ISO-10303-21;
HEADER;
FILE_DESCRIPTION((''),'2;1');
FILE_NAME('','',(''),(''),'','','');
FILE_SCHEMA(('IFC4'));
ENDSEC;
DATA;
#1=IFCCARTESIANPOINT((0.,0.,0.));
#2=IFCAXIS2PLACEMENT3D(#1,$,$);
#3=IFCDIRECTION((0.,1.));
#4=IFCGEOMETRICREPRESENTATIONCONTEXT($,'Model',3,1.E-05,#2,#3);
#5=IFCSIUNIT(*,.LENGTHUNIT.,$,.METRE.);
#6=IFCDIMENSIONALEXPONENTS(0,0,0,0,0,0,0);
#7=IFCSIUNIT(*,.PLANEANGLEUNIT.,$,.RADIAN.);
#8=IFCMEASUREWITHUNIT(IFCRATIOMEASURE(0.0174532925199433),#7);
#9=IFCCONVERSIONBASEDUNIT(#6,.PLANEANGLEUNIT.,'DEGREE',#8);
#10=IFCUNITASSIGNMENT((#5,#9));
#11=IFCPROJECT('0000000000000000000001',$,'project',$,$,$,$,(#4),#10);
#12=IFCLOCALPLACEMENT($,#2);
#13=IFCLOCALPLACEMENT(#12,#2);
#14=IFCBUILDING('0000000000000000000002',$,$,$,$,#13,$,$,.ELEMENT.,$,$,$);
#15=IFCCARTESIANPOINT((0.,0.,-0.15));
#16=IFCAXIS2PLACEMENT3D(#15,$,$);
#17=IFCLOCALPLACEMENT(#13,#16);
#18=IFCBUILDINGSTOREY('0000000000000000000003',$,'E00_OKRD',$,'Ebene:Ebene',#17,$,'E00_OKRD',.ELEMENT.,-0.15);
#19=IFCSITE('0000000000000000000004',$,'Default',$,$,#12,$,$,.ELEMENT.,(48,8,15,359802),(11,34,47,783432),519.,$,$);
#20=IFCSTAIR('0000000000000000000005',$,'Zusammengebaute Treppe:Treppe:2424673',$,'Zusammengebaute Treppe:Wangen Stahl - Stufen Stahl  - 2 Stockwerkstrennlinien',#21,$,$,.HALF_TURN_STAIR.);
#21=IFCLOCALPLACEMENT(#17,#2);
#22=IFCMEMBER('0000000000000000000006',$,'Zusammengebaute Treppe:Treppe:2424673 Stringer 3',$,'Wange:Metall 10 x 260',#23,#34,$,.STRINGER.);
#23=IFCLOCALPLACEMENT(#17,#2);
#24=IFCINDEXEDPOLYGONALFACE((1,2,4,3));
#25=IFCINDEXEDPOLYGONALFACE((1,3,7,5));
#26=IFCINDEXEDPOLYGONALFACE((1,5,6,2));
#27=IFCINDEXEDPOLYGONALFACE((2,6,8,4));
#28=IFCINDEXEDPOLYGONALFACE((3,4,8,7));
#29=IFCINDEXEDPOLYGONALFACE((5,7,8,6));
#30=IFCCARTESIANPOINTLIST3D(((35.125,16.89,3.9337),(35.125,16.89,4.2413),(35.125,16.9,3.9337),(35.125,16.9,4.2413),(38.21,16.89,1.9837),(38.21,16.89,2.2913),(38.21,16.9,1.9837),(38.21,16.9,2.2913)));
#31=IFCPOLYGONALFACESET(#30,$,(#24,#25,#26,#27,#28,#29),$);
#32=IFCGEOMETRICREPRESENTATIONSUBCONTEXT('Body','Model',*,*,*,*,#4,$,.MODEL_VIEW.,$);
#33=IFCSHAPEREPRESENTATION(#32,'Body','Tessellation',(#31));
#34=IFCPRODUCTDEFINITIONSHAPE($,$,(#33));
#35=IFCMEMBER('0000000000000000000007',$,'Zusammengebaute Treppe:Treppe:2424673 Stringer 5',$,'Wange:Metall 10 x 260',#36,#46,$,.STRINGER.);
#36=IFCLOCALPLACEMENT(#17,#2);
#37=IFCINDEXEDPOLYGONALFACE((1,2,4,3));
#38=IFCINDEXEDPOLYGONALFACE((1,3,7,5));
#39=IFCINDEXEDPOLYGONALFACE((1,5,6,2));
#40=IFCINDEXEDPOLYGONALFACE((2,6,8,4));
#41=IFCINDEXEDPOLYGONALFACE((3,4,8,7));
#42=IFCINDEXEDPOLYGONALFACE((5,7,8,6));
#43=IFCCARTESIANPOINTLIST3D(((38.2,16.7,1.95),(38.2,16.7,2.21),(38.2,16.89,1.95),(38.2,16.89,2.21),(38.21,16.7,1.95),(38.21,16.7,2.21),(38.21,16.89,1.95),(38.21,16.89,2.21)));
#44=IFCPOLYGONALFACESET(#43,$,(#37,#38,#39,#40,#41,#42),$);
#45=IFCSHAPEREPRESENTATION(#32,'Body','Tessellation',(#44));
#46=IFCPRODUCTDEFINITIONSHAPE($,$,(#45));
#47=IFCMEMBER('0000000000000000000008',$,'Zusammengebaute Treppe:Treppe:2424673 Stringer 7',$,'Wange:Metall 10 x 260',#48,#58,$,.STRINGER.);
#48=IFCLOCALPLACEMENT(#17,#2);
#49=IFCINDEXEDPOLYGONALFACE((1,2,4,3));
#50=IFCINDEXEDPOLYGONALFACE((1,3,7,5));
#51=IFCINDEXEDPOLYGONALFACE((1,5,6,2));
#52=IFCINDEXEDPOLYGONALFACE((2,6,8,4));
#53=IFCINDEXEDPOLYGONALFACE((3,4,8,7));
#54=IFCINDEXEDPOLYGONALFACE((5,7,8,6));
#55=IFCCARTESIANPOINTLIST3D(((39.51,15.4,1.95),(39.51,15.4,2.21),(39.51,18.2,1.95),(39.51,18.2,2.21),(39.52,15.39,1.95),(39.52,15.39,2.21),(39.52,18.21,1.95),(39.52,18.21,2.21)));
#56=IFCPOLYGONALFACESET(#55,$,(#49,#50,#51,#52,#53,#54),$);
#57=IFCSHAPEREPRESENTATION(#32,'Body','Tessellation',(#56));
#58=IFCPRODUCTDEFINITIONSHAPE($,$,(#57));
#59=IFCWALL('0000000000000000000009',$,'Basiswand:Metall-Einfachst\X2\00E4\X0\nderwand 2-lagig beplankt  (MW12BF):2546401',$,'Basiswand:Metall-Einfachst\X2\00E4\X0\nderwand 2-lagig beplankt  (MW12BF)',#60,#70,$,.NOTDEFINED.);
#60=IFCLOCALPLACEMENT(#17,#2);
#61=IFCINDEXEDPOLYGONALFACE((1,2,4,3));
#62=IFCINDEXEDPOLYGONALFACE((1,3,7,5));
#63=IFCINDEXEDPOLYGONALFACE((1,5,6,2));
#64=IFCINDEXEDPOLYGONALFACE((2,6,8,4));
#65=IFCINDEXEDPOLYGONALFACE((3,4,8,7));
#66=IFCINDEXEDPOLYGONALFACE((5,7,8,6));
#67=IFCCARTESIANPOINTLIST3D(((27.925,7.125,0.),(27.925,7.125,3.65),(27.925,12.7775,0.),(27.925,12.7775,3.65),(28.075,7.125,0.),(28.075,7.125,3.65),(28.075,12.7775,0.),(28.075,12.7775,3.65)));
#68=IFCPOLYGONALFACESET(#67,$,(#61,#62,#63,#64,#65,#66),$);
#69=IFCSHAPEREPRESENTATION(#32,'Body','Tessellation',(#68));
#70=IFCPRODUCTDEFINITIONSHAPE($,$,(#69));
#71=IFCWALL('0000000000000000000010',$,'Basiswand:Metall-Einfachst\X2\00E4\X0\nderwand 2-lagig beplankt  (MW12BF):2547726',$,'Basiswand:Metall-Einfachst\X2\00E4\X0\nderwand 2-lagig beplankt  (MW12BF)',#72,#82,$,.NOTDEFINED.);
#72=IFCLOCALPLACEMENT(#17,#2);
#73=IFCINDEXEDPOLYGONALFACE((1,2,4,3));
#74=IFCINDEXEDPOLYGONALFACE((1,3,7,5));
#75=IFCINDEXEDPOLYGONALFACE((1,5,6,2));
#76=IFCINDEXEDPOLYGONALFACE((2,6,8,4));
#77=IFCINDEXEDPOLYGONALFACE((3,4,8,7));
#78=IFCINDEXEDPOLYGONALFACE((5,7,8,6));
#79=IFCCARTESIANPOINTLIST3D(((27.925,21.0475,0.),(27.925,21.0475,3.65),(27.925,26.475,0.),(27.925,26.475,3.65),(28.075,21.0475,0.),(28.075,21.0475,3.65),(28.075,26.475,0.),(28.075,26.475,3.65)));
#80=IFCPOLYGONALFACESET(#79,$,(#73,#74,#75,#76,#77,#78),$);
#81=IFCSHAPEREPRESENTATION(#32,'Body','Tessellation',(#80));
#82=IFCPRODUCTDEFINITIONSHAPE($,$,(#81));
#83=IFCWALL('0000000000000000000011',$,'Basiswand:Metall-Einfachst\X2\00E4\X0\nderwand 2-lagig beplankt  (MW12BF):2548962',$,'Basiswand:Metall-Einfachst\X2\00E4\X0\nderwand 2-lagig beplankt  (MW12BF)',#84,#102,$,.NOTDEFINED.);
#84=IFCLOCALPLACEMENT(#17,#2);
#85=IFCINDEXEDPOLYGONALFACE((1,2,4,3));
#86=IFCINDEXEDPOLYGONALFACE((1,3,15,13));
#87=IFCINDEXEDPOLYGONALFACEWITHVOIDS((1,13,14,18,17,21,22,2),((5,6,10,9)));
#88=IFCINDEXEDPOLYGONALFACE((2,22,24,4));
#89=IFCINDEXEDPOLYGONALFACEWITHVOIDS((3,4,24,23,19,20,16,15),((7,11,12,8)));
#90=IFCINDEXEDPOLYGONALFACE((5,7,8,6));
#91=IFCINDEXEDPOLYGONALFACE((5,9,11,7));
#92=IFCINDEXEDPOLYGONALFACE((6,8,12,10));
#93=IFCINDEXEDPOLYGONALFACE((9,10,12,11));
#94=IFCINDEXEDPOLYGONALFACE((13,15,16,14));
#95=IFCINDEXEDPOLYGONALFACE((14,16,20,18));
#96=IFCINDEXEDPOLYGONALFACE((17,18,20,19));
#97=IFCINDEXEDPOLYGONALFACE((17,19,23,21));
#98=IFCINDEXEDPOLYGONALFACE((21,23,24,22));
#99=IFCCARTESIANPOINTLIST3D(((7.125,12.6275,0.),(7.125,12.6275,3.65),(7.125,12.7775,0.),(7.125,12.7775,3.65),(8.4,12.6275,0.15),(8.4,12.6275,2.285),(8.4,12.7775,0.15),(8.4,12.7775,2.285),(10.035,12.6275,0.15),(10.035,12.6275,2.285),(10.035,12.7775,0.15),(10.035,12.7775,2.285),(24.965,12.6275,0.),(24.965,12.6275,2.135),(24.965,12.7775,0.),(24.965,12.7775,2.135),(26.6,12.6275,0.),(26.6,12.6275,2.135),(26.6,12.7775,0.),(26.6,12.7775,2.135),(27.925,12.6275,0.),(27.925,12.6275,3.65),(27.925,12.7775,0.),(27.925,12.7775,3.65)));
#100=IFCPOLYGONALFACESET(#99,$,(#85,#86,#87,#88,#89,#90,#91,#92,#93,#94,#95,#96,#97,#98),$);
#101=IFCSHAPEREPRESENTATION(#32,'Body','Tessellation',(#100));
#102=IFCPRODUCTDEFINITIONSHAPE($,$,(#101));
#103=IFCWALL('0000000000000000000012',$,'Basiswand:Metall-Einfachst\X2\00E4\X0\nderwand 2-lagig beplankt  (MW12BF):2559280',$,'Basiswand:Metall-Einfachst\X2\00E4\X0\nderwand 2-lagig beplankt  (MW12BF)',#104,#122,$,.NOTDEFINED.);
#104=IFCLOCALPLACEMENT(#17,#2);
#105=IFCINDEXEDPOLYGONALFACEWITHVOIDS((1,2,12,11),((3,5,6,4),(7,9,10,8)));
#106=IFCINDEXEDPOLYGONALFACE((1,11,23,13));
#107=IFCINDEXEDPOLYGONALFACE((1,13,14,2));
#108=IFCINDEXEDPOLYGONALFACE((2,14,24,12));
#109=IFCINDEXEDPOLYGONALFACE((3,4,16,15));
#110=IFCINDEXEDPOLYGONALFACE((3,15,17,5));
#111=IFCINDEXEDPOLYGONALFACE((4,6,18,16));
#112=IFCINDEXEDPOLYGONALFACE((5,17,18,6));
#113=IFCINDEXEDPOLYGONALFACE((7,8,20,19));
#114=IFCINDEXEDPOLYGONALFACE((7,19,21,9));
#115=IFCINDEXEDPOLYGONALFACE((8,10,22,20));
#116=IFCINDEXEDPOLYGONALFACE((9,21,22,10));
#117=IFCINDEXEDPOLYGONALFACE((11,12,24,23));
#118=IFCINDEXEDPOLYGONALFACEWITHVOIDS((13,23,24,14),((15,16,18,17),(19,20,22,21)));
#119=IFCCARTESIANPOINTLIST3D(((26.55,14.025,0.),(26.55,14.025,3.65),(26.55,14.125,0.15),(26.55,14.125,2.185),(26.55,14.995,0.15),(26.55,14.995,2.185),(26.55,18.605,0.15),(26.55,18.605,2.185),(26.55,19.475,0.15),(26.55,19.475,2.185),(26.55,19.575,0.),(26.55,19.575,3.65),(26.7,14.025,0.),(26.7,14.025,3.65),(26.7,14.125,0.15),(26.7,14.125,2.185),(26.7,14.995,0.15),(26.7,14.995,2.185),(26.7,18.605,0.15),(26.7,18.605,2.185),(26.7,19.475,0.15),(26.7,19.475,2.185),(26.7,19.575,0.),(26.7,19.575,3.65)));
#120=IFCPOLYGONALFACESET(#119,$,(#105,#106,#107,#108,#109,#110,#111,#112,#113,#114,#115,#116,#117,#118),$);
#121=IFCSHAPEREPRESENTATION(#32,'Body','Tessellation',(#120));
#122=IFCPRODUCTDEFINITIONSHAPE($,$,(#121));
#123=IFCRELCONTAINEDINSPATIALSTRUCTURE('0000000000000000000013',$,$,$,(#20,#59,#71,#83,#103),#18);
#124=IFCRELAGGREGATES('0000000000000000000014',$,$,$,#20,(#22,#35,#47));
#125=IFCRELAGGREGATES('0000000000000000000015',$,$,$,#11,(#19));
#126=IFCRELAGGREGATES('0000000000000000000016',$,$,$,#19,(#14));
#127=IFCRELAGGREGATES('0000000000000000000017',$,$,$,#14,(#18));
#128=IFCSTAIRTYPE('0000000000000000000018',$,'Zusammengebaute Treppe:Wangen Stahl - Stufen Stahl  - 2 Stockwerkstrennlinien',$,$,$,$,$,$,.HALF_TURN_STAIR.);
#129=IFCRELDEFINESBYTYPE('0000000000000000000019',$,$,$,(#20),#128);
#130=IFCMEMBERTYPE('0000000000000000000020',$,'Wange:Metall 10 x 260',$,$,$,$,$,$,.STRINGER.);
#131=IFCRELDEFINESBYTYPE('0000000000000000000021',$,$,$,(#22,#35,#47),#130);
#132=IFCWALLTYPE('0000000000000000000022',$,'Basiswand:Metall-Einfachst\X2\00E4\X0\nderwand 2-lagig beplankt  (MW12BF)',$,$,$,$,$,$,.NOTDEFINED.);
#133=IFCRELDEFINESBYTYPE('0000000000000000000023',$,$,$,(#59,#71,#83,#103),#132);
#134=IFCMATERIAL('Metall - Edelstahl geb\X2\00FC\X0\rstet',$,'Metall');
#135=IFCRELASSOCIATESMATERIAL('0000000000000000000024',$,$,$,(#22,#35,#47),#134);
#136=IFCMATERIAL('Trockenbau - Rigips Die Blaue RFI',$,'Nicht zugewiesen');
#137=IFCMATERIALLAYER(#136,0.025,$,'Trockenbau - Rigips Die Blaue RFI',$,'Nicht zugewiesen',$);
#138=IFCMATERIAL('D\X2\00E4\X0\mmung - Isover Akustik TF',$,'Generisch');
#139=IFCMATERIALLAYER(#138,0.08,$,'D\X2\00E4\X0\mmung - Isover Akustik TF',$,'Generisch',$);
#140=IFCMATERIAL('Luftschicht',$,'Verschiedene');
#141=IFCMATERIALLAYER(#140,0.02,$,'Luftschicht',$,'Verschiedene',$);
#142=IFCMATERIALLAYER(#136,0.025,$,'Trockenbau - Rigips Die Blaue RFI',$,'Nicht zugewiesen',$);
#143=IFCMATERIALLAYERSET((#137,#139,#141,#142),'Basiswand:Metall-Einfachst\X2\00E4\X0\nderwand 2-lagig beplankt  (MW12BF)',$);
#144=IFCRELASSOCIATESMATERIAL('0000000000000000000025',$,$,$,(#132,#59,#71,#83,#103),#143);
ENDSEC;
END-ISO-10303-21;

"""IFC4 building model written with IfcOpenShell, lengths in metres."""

from ifc_helpers import new_model, entity, si_unit, converted_unit, direction, frame, frame_2d, origin, place, context, subcontext, project, spatial, polyline, rectangle, outline, extrude, material, layer, layer_set, layer_usage, type_object, element, aggregate, save


model = new_model("IFC4")

# Units and contexts
model_context = context("Model", 3, precision=1e-05, world=origin(), true_north=direction((0.0, 1.0)))
body_context = subcontext(model_context, "Body", "Model", "MODEL_VIEW")
ifc_project = project(units=[si_unit("LENGTHUNIT", "METRE"), converted_unit("PLANEANGLEUNIT", "DEGREE", entity("IfcRatioMeasure", 0.0174532925199433), si_unit("PLANEANGLEUNIT", "RADIAN"), dimensions=[0, 0, 0, 0, 0, 0, 0])], contexts=[model_context])

# Site, building, storey
site_placement = place(None, frame((0.0, 0.0, 0.0)))
site = spatial("IfcSite", under=ifc_project, at=site_placement, Name="Default", CompositionType="ELEMENT", RefLatitude=(48, 8, 15, 359802), RefLongitude=(11, 34, 47, 783432), RefElevation=519.0)
building_placement = place(site_placement, origin())
building = spatial("IfcBuilding", under=site, at=building_placement, CompositionType="ELEMENT")
storey_placement = place(building_placement, frame((0.0, 0.0, -0.15)))
storey = spatial("IfcBuildingStorey", under=building, at=storey_placement, Name="E00_OKRD", ObjectType="Ebene:Ebene", LongName="E00_OKRD", CompositionType="ELEMENT", Elevation=-0.15)

# Stair, members
stair_type = type_object("IfcStairType", Name="Zusammengebaute Treppe:Wangen Stahl - Stufen Stahl  - 2 Stockwerkstrennlinien", PredefinedType="HALF_TURN_STAIR")
stair_placement = place(storey_placement, origin())
stair = element("IfcStair", 1, at=stair_placement, inside=storey, type_object=stair_type, Name="Zusammengebaute Treppe:Treppe:2424673", ObjectType="Zusammengebaute Treppe:Wangen Stahl - Stufen Stahl  - 2 Stockwerkstrennlinien", PredefinedType="HALF_TURN_STAIR")
ifc_material_1 = material(Name="Metall - Edelstahl gebürstet", Category="Metall")
member_type_1 = type_object("IfcMemberType", Name="Wange:Metall 10 x 260", PredefinedType="STRINGER")
member_1_placement = place(stair_placement, frame((35.125, 16.89, 1.9837)))
member_1 = element("IfcMember", 2, at=member_1_placement, type_object=member_type_1, material=ifc_material_1, Name="Zusammengebaute Treppe:Treppe:2424673 Stringer 3", ObjectType="Wange:Metall 10 x 260", PredefinedType="STRINGER", context=body_context, shape_type="SweptSolid", body=[
    extrude(outline(polyline([(-1.907, -0.13), (1.7426, -0.13), (1.907, 0.13), (-1.7426, 0.13), (-1.907, -0.13)])), frame((1.5425, 0.0, 1.1288), z_axis=(0.0, 1.0, 0.0), x_axis=(-0.845294, 0.0, 0.534302)), (0.0, 0.0, 1.0), 0.01),
])
member_2_placement = place(stair_placement, frame((38.2, 16.7, 1.95)))
member_2 = element("IfcMember", 3, at=member_2_placement, type_object=member_type_1, material=ifc_material_1, Name="Zusammengebaute Treppe:Treppe:2424673 Stringer 5", ObjectType="Wange:Metall 10 x 260", PredefinedType="STRINGER", context=body_context, shape_type="SweptSolid", body=[
    extrude(rectangle(XDim=0.19, YDim=0.01, at=frame_2d((0.0, 0.0), x_axis=(1.0, 0.0))), frame((0.005, 0.095, 0.0), z_axis=(0.0, 0.0, 1.0), x_axis=(0.0, -1.0, 0.0)), (0.0, 0.0, 1.0), 0.26),
])
member_3_placement = place(stair_placement, frame((39.51, 15.39, 1.95)))
member_3 = element("IfcMember", 4, at=member_3_placement, type_object=member_type_1, material=ifc_material_1, Name="Zusammengebaute Treppe:Treppe:2424673 Stringer 7", ObjectType="Wange:Metall 10 x 260", PredefinedType="STRINGER", context=body_context, shape_type="SweptSolid", body=[
    extrude(outline(polyline([(-1.41, -0.005), (1.41, -0.005), (1.4, 0.005), (-1.4, 0.005), (-1.41, -0.005)])), frame((0.005, 1.41, 0.0), z_axis=(0.0, 0.0, 1.0), x_axis=(0.0, 1.0, 0.0)), (0.0, 0.0, 1.0), 0.26),
])

# Walls
ifc_material_2 = material(Name="Trockenbau - Rigips Die Blaue RFI", Category="Nicht zugewiesen")
ifc_layer_1 = layer(ifc_material_2, 0.025, Name="Trockenbau - Rigips Die Blaue RFI", Category="Nicht zugewiesen")
ifc_material_3 = material(Name="Dämmung - Isover Akustik TF", Category="Generisch")
ifc_layer_2 = layer(ifc_material_3, 0.08, Name="Dämmung - Isover Akustik TF", Category="Generisch")
ifc_material_4 = material(Name="Luftschicht", Category="Verschiedene")
ifc_layer_3 = layer(ifc_material_4, 0.02, Name="Luftschicht", Category="Verschiedene")
ifc_layer_4 = layer(ifc_material_2, 0.025, Name="Trockenbau - Rigips Die Blaue RFI", Category="Nicht zugewiesen")
ifc_layer_set_1 = layer_set([ifc_layer_1, ifc_layer_2, ifc_layer_3, ifc_layer_4], Name="Basiswand:Metall-Einfachständerwand 2-lagig beplankt  (MW12BF)")
ifc_layer_usage_1 = layer_usage(ifc_layer_set_1, "AXIS2", "NEGATIVE", 0.075)
wall_type = type_object("IfcWallType", Name="Basiswand:Metall-Einfachständerwand 2-lagig beplankt  (MW12BF)", PredefinedType="NOTDEFINED", material=ifc_layer_set_1)
wall_1_placement = place(storey_placement, frame((28.0, 7.125, 0.0), z_axis=(0.0, 0.0, 1.0), x_axis=(0.0, 1.0, 0.0)))
element("IfcWall", 5, at=wall_1_placement, inside=storey, type_object=wall_type, material=ifc_layer_usage_1, Name="Basiswand:Metall-Einfachständerwand 2-lagig beplankt  (MW12BF):2546401", ObjectType="Basiswand:Metall-Einfachständerwand 2-lagig beplankt  (MW12BF)", PredefinedType="NOTDEFINED", context=body_context, shape_type="SweptSolid", body=[
    extrude(rectangle(XDim=5.6525, YDim=0.15, at=frame_2d((2.8263, 0.0), x_axis=(-1.0, 0.0))), origin(), (0.0, 0.0, 1.0), 3.65),
])
ifc_layer_usage_2 = layer_usage(ifc_layer_set_1, "AXIS2", "NEGATIVE", 0.075)
wall_2_placement = place(storey_placement, frame((28.0, 26.475, 0.0), z_axis=(0.0, 0.0, 1.0), x_axis=(0.0, -1.0, 0.0)))
element("IfcWall", 6, at=wall_2_placement, inside=storey, type_object=wall_type, material=ifc_layer_usage_2, Name="Basiswand:Metall-Einfachständerwand 2-lagig beplankt  (MW12BF):2547726", ObjectType="Basiswand:Metall-Einfachständerwand 2-lagig beplankt  (MW12BF)", PredefinedType="NOTDEFINED", context=body_context, shape_type="SweptSolid", body=[
    extrude(rectangle(XDim=5.4275, YDim=0.15, at=frame_2d((2.7137, 0.0), x_axis=(-1.0, 0.0))), origin(), (0.0, 0.0, 1.0), 3.65),
])

# Walls, openings
ifc_layer_usage_3 = layer_usage(ifc_layer_set_1, "AXIS2", "NEGATIVE", 0.075)
wall_3_placement = place(storey_placement, frame((27.925, 12.7025, 0.0), z_axis=(0.0, 0.0, 1.0), x_axis=(-1.0, 0.0, 0.0)))
wall_3 = element("IfcWall", 7, at=wall_3_placement, inside=storey, type_object=wall_type, material=ifc_layer_usage_3, Name="Basiswand:Metall-Einfachständerwand 2-lagig beplankt  (MW12BF):2548962", ObjectType="Basiswand:Metall-Einfachständerwand 2-lagig beplankt  (MW12BF)", PredefinedType="NOTDEFINED", context=body_context, shape_type="SweptSolid", body=[
    extrude(rectangle(XDim=20.8, YDim=0.15, at=frame_2d((10.4, 0.0), x_axis=(-1.0, 0.0))), origin(), (0.0, 0.0, 1.0), 3.65),
])
opening_1_placement = place(wall_3_placement, frame((14.05, -0.075, 0.15)))
element("IfcOpeningElement", 8, at=opening_1_placement, cuts=wall_3, ObjectType="Opening", PredefinedType="OPENING", context=body_context, shape_type="SweptSolid", body=[
    extrude(rectangle(XDim=2.045, YDim=0.15, at=frame_2d((0.0, 0.0), x_axis=(0.0, 1.0))), frame((-0.075, -1.09, 1.0225), z_axis=(0.0, 1.0, 0.0), x_axis=(1.0, 0.0, 0.0)), (0.0, 0.0, 1.0), 1.09),
])
opening_2_placement = place(wall_3_placement, frame((1.325, -0.075, 0.0)))
element("IfcOpeningElement", 9, at=opening_2_placement, cuts=wall_3, ObjectType="Opening", PredefinedType="OPENING", context=body_context, shape_type="SweptSolid", body=[
    extrude(rectangle(XDim=2.135, YDim=1.635, at=frame_2d((1.0675, 0.8175), x_axis=(-1.0, 0.0))), frame((0.0, 0.0, 0.0), z_axis=(0.0, 1.0, 0.0), x_axis=(0.0, 0.0, 1.0)), (0.0, 0.0, 1.0), 0.15),
])
opening_3_placement = place(wall_3_placement, frame((17.89, -0.075, 0.15)))
element("IfcOpeningElement", 10, at=opening_3_placement, cuts=wall_3, ObjectType="Opening", PredefinedType="OPENING", context=body_context, shape_type="SweptSolid", body=[
    extrude(rectangle(XDim=2.135, YDim=1.635, at=frame_2d((1.0675, 0.8175), x_axis=(-1.0, 0.0))), frame((0.0, 0.0, 0.0), z_axis=(0.0, 1.0, 0.0), x_axis=(0.0, 0.0, 1.0)), (0.0, 0.0, 1.0), 0.15),
])
ifc_layer_usage_4 = layer_usage(ifc_layer_set_1, "AXIS2", "NEGATIVE", 0.075)
wall_4_placement = place(storey_placement, frame((26.625, 19.575, 0.0), z_axis=(0.0, 0.0, 1.0), x_axis=(0.0, -1.0, 0.0)))
wall_4 = element("IfcWall", 11, at=wall_4_placement, inside=storey, type_object=wall_type, material=ifc_layer_usage_4, Name="Basiswand:Metall-Einfachständerwand 2-lagig beplankt  (MW12BF):2559280", ObjectType="Basiswand:Metall-Einfachständerwand 2-lagig beplankt  (MW12BF)", PredefinedType="NOTDEFINED", context=body_context, shape_type="SweptSolid", body=[
    extrude(rectangle(XDim=5.55, YDim=0.15, at=frame_2d((2.775, 0.0), x_axis=(-1.0, 0.0))), origin(), (0.0, 0.0, 1.0), 3.65),
])
opening_4_placement = place(wall_4_placement, frame((5.45, 0.075, 0.15)))
element("IfcOpeningElement", 12, at=opening_4_placement, cuts=wall_4, ObjectType="Opening", PredefinedType="OPENING", context=body_context, shape_type="SweptSolid", body=[
    extrude(rectangle(XDim=2.035, YDim=0.87, at=frame_2d((1.0175, 0.435), x_axis=(-1.0, 0.0))), frame((0.0, 0.0, 0.0), z_axis=(0.0, -1.0, 0.0), x_axis=(0.0, 0.0, 1.0)), (0.0, 0.0, 1.0), 0.15),
])
opening_5_placement = place(wall_4_placement, frame((0.97, 0.075, 0.15)))
element("IfcOpeningElement", 13, at=opening_5_placement, cuts=wall_4, ObjectType="Opening", PredefinedType="OPENING", context=body_context, shape_type="SweptSolid", body=[
    extrude(rectangle(XDim=2.035, YDim=0.87, at=frame_2d((1.0175, 0.435), x_axis=(-1.0, 0.0))), frame((0.0, 0.0, 0.0), z_axis=(0.0, -1.0, 0.0), x_axis=(0.0, 0.0, 1.0)), (0.0, 0.0, 1.0), 0.15),
])

aggregate(stair, [member_1, member_2, member_3])

save(model, "model.ifc")
